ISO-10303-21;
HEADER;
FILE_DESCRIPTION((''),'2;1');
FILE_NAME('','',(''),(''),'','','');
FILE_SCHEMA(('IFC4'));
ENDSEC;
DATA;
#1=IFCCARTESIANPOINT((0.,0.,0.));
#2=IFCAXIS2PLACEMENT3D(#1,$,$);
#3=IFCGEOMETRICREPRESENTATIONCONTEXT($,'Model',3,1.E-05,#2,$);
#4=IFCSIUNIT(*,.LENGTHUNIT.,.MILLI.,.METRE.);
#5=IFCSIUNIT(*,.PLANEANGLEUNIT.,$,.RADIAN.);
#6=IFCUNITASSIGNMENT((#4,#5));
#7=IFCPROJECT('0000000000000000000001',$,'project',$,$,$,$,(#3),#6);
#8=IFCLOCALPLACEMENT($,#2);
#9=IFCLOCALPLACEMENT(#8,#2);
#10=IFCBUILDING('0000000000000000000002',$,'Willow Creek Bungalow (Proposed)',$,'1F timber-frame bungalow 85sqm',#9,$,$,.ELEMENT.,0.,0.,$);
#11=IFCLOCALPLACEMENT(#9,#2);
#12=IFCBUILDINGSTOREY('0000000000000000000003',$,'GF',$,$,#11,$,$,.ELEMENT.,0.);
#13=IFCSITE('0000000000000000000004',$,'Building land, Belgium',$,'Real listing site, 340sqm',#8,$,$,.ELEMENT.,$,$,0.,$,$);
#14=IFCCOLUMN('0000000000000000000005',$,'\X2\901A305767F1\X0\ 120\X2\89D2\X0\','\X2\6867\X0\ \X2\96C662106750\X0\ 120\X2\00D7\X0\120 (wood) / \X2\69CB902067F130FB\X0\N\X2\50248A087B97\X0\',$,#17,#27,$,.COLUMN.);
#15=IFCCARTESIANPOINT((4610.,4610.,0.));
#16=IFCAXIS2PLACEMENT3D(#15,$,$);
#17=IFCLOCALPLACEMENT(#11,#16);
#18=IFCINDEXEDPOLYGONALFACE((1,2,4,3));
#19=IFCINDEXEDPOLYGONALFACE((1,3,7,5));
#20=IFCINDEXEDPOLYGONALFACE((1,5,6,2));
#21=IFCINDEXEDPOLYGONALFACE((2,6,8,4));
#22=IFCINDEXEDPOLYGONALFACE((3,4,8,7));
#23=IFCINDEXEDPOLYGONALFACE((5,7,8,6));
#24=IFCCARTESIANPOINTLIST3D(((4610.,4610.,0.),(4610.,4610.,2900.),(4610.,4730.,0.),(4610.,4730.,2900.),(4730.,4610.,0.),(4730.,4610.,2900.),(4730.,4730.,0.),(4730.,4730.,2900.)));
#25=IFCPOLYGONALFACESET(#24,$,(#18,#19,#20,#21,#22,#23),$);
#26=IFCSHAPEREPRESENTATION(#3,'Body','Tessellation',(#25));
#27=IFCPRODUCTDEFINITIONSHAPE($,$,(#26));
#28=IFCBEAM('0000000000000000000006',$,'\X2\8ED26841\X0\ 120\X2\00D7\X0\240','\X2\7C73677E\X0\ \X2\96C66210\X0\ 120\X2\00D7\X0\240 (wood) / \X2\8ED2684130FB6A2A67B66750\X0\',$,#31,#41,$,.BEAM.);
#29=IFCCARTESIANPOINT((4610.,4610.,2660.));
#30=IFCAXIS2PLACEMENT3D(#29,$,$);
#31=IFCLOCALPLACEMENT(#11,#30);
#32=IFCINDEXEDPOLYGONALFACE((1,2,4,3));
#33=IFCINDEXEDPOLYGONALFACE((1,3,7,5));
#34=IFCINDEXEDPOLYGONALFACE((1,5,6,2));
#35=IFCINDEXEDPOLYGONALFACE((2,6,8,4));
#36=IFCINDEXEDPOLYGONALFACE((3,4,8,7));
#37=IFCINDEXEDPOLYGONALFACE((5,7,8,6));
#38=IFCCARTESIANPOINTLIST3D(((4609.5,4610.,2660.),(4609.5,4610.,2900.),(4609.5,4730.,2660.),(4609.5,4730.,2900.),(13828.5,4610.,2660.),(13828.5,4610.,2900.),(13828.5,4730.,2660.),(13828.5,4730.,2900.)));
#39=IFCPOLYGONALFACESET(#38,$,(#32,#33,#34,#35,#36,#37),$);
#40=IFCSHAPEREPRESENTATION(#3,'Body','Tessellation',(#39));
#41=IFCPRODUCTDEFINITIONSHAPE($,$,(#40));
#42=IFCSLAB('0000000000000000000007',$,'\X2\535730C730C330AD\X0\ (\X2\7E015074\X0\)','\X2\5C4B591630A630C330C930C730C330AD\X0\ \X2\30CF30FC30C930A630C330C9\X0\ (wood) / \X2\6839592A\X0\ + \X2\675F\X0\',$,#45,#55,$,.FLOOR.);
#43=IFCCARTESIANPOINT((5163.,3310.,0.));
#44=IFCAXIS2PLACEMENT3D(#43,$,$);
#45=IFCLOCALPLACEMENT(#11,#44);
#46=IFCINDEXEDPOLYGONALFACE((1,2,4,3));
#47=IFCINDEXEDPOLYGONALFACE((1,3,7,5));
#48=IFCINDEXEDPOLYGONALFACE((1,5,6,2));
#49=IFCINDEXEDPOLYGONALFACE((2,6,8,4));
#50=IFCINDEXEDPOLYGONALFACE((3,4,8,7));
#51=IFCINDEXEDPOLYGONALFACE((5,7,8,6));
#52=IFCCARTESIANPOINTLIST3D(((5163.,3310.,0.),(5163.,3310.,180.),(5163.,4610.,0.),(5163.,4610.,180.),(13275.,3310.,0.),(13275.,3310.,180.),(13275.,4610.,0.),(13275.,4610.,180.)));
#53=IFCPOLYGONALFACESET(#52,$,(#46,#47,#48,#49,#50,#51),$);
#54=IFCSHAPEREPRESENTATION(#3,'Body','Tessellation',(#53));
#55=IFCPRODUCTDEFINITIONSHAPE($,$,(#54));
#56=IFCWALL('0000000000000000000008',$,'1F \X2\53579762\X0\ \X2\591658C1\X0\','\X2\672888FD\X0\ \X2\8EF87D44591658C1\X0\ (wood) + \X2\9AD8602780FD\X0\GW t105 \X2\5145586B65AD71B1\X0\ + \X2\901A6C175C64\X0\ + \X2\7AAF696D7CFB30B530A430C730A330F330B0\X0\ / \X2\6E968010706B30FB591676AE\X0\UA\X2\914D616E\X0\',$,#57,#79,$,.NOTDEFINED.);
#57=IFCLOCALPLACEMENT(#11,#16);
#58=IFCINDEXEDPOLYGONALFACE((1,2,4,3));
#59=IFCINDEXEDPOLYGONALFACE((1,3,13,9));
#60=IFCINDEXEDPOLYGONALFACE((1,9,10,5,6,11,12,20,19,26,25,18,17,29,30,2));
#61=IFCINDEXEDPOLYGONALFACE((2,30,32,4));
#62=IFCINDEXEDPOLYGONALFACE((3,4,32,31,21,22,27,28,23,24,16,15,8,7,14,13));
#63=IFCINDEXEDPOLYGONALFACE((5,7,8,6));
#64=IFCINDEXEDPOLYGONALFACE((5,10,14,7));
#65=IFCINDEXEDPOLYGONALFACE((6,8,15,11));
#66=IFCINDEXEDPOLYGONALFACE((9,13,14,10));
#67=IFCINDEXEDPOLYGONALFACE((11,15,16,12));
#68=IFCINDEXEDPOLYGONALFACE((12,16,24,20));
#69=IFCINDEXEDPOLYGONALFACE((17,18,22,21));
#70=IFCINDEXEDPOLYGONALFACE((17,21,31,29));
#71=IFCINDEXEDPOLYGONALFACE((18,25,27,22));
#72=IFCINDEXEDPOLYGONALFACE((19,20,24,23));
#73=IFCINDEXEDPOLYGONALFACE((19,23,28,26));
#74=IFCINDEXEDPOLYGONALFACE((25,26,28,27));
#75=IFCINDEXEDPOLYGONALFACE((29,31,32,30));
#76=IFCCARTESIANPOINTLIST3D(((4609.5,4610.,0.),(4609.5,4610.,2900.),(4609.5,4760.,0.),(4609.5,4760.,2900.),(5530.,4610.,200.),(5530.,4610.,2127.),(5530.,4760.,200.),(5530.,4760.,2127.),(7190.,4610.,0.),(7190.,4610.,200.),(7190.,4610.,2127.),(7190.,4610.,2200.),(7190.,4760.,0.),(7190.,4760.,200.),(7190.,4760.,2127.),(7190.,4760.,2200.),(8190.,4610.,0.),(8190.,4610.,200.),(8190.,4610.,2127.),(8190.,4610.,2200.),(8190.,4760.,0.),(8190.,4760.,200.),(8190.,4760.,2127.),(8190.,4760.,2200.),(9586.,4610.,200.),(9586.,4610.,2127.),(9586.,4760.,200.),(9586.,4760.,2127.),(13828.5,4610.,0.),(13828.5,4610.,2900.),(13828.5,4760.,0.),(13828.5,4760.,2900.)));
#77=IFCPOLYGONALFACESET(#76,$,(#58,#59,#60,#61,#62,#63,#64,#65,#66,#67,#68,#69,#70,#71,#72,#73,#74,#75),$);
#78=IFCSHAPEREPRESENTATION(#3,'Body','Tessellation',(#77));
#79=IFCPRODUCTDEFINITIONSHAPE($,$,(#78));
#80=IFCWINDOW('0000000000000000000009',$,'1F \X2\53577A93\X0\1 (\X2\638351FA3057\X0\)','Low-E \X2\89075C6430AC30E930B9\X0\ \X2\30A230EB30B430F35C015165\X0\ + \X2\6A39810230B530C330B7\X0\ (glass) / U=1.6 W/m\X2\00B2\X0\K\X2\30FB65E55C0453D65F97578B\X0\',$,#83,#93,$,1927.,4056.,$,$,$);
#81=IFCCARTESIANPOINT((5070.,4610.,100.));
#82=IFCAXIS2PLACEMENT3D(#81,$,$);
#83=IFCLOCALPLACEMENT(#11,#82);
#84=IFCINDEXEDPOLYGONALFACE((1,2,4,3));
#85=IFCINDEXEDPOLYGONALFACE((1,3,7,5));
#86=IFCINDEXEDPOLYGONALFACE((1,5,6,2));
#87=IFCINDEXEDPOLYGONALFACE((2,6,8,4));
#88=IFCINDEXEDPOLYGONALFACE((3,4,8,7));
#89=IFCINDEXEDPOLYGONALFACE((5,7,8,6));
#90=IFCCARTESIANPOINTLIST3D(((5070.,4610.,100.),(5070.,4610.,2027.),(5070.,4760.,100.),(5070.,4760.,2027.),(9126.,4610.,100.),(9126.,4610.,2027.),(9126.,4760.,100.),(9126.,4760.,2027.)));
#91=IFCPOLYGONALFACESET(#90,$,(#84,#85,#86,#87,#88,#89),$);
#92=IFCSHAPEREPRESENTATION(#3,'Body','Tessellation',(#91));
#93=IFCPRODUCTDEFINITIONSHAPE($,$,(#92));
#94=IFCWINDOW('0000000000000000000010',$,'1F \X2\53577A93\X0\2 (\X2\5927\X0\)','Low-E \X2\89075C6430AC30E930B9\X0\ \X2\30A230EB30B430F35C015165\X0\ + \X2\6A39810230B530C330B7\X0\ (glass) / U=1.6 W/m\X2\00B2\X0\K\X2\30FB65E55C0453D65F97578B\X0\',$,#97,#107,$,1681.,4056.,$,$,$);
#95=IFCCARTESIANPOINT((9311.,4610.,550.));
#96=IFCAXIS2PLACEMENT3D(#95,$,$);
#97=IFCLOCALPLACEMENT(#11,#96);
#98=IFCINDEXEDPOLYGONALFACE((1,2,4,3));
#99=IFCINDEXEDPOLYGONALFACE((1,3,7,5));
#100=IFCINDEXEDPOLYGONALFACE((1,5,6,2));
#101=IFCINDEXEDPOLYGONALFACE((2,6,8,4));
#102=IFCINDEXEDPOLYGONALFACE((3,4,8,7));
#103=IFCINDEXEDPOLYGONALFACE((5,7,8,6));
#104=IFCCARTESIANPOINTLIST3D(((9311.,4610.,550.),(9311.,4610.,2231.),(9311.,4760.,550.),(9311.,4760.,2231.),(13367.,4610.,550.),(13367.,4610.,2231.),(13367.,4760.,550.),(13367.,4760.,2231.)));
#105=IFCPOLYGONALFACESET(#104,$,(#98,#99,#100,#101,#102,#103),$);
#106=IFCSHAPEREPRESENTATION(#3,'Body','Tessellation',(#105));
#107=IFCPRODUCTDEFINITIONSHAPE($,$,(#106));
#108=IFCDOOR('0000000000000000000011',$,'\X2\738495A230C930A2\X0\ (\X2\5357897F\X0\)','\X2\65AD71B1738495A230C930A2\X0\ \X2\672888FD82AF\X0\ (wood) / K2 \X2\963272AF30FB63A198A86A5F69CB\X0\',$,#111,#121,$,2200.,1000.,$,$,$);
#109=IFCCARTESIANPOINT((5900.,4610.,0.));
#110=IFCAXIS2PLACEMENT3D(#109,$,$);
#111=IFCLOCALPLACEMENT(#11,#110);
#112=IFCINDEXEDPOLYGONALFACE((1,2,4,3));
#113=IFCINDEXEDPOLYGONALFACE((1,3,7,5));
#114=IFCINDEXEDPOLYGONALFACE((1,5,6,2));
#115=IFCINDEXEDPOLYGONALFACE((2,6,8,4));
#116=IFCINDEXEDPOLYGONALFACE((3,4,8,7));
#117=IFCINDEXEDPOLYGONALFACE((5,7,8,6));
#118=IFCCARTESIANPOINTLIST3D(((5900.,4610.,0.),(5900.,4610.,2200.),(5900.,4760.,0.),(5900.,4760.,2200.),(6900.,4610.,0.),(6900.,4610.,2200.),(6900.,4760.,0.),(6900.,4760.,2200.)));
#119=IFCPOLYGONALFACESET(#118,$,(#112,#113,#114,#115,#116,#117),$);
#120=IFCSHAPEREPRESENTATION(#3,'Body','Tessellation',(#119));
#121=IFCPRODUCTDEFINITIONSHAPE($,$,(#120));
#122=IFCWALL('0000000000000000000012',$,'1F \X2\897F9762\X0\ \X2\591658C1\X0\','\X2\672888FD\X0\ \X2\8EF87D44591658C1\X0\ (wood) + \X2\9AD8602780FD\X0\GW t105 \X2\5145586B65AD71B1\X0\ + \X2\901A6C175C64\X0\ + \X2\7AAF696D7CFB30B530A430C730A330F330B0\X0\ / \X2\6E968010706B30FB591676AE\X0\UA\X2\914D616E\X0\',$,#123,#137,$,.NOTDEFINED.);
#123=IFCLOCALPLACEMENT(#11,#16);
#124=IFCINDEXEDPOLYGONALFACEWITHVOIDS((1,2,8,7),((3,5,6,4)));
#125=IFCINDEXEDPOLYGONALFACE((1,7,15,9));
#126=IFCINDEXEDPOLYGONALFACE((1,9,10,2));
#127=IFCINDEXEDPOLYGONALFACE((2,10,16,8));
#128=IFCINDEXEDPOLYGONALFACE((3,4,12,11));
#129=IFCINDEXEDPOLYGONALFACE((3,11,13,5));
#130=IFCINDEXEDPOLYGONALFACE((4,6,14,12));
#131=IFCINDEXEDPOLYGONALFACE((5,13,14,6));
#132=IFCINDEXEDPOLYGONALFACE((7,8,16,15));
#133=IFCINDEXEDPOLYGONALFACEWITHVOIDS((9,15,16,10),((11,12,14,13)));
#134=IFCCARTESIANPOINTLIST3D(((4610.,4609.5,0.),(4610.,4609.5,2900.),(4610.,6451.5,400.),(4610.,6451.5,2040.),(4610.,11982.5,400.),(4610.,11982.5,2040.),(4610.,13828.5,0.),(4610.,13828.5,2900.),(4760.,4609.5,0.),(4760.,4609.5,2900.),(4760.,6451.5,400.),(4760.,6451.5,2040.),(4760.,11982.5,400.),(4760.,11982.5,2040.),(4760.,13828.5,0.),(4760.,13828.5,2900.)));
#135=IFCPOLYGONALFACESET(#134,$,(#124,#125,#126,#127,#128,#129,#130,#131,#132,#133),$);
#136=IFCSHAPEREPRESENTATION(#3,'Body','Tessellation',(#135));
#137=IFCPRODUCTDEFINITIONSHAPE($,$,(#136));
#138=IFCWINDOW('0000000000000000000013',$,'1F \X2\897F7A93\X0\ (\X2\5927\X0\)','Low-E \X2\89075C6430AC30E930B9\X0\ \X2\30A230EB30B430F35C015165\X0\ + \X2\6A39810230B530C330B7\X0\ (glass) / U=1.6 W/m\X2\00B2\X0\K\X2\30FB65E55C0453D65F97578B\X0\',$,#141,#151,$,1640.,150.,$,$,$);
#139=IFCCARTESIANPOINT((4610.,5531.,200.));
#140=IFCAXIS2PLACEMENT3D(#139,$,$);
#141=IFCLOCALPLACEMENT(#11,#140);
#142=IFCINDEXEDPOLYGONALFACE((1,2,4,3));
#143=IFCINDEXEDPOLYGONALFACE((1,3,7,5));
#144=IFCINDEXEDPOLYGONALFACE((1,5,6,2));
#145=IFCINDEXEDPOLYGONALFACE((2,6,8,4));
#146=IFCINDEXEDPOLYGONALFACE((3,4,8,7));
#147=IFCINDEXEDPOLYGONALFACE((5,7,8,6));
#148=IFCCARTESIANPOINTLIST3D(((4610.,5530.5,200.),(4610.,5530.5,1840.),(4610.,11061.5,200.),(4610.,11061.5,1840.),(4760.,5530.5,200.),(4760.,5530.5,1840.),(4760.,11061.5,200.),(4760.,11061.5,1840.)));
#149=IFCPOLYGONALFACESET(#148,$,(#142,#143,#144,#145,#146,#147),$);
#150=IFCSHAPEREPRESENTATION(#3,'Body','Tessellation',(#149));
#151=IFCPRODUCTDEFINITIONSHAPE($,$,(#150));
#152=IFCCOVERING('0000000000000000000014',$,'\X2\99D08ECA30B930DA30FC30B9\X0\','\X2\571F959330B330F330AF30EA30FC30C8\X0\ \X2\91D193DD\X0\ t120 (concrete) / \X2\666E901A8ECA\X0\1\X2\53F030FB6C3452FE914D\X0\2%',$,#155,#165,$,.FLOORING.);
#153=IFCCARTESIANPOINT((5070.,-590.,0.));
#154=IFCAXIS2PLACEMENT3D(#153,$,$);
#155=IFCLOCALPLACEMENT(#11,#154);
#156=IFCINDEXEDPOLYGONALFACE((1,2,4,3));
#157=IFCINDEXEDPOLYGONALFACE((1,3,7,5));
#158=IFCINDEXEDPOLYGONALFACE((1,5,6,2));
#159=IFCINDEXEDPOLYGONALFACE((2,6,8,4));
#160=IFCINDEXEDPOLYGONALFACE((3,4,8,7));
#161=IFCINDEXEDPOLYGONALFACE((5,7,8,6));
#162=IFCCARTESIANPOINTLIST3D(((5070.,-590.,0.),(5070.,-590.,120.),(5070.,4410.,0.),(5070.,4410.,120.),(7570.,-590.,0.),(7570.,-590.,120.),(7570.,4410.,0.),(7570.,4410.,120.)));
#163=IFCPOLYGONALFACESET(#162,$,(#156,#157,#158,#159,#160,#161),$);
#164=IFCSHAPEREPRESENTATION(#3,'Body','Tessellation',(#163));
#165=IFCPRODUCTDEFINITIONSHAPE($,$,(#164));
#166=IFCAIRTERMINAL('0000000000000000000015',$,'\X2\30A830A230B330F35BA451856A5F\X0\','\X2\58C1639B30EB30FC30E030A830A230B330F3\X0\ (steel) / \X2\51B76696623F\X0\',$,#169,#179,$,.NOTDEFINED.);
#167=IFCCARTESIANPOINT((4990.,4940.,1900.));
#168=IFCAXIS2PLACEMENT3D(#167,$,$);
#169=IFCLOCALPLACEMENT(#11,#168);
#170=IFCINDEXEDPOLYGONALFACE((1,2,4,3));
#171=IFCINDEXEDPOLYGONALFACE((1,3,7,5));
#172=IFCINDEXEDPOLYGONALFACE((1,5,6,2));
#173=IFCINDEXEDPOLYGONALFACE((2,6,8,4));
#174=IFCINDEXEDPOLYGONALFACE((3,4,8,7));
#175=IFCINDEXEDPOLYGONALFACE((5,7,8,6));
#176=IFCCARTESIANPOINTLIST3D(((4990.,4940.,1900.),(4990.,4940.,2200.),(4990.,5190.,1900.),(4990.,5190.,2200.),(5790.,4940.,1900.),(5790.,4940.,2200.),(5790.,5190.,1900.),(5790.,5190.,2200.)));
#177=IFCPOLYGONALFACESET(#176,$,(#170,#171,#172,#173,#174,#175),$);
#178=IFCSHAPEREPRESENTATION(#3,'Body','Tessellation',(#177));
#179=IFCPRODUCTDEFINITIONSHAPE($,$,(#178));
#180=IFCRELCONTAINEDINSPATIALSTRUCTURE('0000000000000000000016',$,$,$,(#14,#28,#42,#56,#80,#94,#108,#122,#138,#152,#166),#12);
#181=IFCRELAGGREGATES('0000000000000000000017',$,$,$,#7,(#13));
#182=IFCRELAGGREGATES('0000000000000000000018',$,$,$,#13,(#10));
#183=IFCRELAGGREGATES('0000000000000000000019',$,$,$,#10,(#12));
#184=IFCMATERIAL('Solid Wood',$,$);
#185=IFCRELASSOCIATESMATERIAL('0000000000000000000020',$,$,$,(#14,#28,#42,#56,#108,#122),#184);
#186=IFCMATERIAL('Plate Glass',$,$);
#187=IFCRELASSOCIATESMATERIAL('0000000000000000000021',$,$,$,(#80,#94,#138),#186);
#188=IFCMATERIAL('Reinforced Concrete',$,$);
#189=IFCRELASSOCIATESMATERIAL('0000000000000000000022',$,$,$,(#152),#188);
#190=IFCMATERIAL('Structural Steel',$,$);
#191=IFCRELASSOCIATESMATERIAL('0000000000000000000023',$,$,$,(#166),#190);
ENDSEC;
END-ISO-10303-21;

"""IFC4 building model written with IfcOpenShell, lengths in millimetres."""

from ifc_helpers import new_model, si_unit, frame, frame_2d, origin, place, context, project, spatial, rectangle, extrude, material, element, fill, save


model = new_model("IFC4")

# Units and contexts
model_context = context("Model", 3, precision=1e-05, world=origin())
ifc_project = project(units=[si_unit("LENGTHUNIT", "METRE", prefix="MILLI"), si_unit("PLANEANGLEUNIT", "RADIAN")], contexts=[model_context])

# Site, building, storey
site_placement = place(None, origin())
site = spatial("IfcSite", under=ifc_project, at=site_placement, Name="Building land, Belgium", ObjectType="Real listing site, 340sqm", CompositionType="ELEMENT", RefElevation=0.0)
building_placement = place(site_placement, origin())
building = spatial("IfcBuilding", under=site, at=building_placement, Name="Willow Creek Bungalow (Proposed)", ObjectType="1F timber-frame bungalow 85sqm", CompositionType="ELEMENT", ElevationOfRefHeight=0.0, ElevationOfTerrain=0.0)
storey_placement = place(building_placement, origin())
storey = spatial("IfcBuildingStorey", under=building, at=storey_placement, Name="GF", CompositionType="ELEMENT", Elevation=0.0)

# Column
ifc_material_1 = material(Name="Solid Wood")
column_1_placement = place(storey_placement, frame((4610.0, 4610.0, 0.0)))
element("IfcColumn", 1, at=column_1_placement, inside=storey, material=ifc_material_1, Name="通し柱 120角", Description="桧 集成材 120×120 (wood) / 構造柱・N値計算", PredefinedType="COLUMN", context=model_context, shape_type="SweptSolid", body=[
    extrude(rectangle(XDim=120.0, YDim=120.0, at=frame_2d((60.0, 60.0))), frame((4610.0, 4610.0, 0.0)), (0.0, 0.0, 1.0), 2900.0),
])

# Beam
beam_1_placement = place(storey_placement, frame((4610.0, 4610.0, 2660.0)))
element("IfcBeam", 2, at=beam_1_placement, inside=storey, material=ifc_material_1, Name="軒桁 120×240", Description="米松 集成 120×240 (wood) / 軒桁・横架材", PredefinedType="BEAM", context=model_context, shape_type="SweptSolid", body=[
    extrude(rectangle(XDim=9219.0, YDim=120.0, at=frame_2d((4609.0, 60.0))), frame((4610.0, 4610.0, 2660.0)), (0.0, 0.0, 1.0), 240.0),
])

# Slab
ifc_material_2 = material(Name="Reinforced Concrete")
slab_1_placement = place(storey_placement, frame((5163.0, 3310.0, 0.0)))
element("IfcSlab", 3, at=slab_1_placement, inside=storey, material=ifc_material_1, Name="南デッキ (縁側)", Description="屋外ウッドデッキ ハードウッド (wood) / 根太 + 束", PredefinedType="FLOOR", context=model_context, shape_type="SweptSolid", body=[
    extrude(rectangle(XDim=8112.0, YDim=1300.0, at=frame_2d((4056.0, 650.0))), frame((5163.0, 3310.0, 0.0)), (0.0, 0.0, 1.0), 180.0),
])

# Wall, openings, windows, door
wall_1_placement = place(storey_placement, frame((4610.0, 4610.0, 0.0)))
wall_1 = element("IfcWall", 4, at=wall_1_placement, inside=storey, material=ifc_material_1, Name="1F 南面 外壁", Description="木製 軸組外壁 (wood) + 高性能GW t105 充填断熱 + 通気層 + 窯業系サイディング / 準耐火・外皮UA配慮", PredefinedType="NOTDEFINED", context=model_context, shape_type="SweptSolid", body=[
    extrude(rectangle(XDim=9219.0, YDim=150.0, at=frame_2d((4609.0, 75.0))), frame((4610.0, 4610.0, 0.0)), (0.0, 0.0, 1.0), 2900.0),
])
opening_1_placement = place(storey_placement, frame((5070.0, 4610.0, 100.0)))
opening_1 = element("IfcOpeningElement", 5, at=opening_1_placement, cuts=wall_1, PredefinedType="NOTDEFINED", context=model_context, shape_type="SweptSolid", body=[
    extrude(rectangle(XDim=4056.0, YDim=150.0, at=frame_2d((2028.0, 75.0))), frame((5070.0, 4610.0, 100.0)), (0.0, 0.0, 1.0), 1927.0),
])
opening_2_placement = place(storey_placement, frame((9311.0, 4610.0, 550.0)))
opening_2 = element("IfcOpeningElement", 6, at=opening_2_placement, cuts=wall_1, PredefinedType="NOTDEFINED", context=model_context, shape_type="SweptSolid", body=[
    extrude(rectangle(XDim=4056.0, YDim=150.0, at=frame_2d((2028.0, 75.0))), frame((9311.0, 4610.0, 550.0)), (0.0, 0.0, 1.0), 1681.0),
])
opening_3_placement = place(storey_placement, frame((5900.0, 4610.0, 0.0)))
opening_3 = element("IfcOpeningElement", 7, at=opening_3_placement, cuts=wall_1, PredefinedType="NOTDEFINED", context=model_context, shape_type="SweptSolid", body=[
    extrude(rectangle(XDim=1000.0, YDim=150.0, at=frame_2d((500.0, 75.0))), frame((5900.0, 4610.0, 0.0)), (0.0, 0.0, 1.0), 2200.0),
])
ifc_material_3 = material(Name="Plate Glass")
window_1_placement = place(storey_placement, frame((5070.0, 4610.0, 100.0)))
window_1 = element("IfcWindow", 8, at=window_1_placement, inside=storey, material=ifc_material_3, Name="1F 南窓1 (掃出し)", Description="Low-E 複層ガラス アルゴン封入 + 樹脂サッシ (glass) / U=1.6 W/m²K・日射取得型", OverallHeight=1927.0, OverallWidth=4056.0, context=model_context, shape_type="SweptSolid", body=[
    extrude(rectangle(XDim=4056.0, YDim=150.0, at=frame_2d((2028.0, 75.0))), frame((5070.0, 4610.0, 100.0)), (0.0, 0.0, 1.0), 1927.0),
])
fill(opening_1, window_1)
window_2_placement = place(storey_placement, frame((9311.0, 4610.0, 550.0)))
window_2 = element("IfcWindow", 9, at=window_2_placement, inside=storey, material=ifc_material_3, Name="1F 南窓2 (大)", Description="Low-E 複層ガラス アルゴン封入 + 樹脂サッシ (glass) / U=1.6 W/m²K・日射取得型", OverallHeight=1681.0, OverallWidth=4056.0, context=model_context, shape_type="SweptSolid", body=[
    extrude(rectangle(XDim=4056.0, YDim=150.0, at=frame_2d((2028.0, 75.0))), frame((9311.0, 4610.0, 550.0)), (0.0, 0.0, 1.0), 1681.0),
])
fill(opening_2, window_2)
door_placement = place(storey_placement, frame((5900.0, 4610.0, 0.0)))
door = element("IfcDoor", 10, at=door_placement, inside=storey, material=ifc_material_1, Name="玄関ドア (南西)", Description="断熱玄関ドア 木製芯 (wood) / K2 防犯・採風機構", OverallHeight=2200.0, OverallWidth=1000.0, context=model_context, shape_type="SweptSolid", body=[
    extrude(rectangle(XDim=1000.0, YDim=150.0, at=frame_2d((500.0, 75.0))), frame((5900.0, 4610.0, 0.0)), (0.0, 0.0, 1.0), 2200.0),
])
fill(opening_3, door)

# Wall, opening, window
wall_2_placement = place(storey_placement, frame((4610.0, 4610.0, 0.0)))
wall_2 = element("IfcWall", 11, at=wall_2_placement, inside=storey, material=ifc_material_1, Name="1F 西面 外壁", Description="木製 軸組外壁 (wood) + 高性能GW t105 充填断熱 + 通気層 + 窯業系サイディング / 準耐火・外皮UA配慮", PredefinedType="NOTDEFINED", context=model_context, shape_type="SweptSolid", body=[
    extrude(rectangle(XDim=150.0, YDim=9219.0, at=frame_2d((75.0, 4609.0))), frame((4610.0, 4610.0, 0.0)), (0.0, 0.0, 1.0), 2900.0),
])
opening_4_placement = place(storey_placement, frame((4610.0, 5531.0, 200.0)))
opening_4 = element("IfcOpeningElement", 12, at=opening_4_placement, cuts=wall_2, PredefinedType="NOTDEFINED", context=model_context, shape_type="SweptSolid", body=[
    extrude(rectangle(XDim=150.0, YDim=5531.0, at=frame_2d((75.0, 2765.0))), frame((4610.0, 5531.0, 200.0)), (0.0, 0.0, 1.0), 1640.0),
])
window_3_placement = place(storey_placement, frame((4610.0, 5531.0, 200.0)))
window_3 = element("IfcWindow", 13, at=window_3_placement, inside=storey, material=ifc_material_3, Name="1F 西窓 (大)", Description="Low-E 複層ガラス アルゴン封入 + 樹脂サッシ (glass) / U=1.6 W/m²K・日射取得型", OverallHeight=1640.0, OverallWidth=150.0, context=model_context, shape_type="SweptSolid", body=[
    extrude(rectangle(XDim=150.0, YDim=5531.0, at=frame_2d((75.0, 2765.0))), frame((4610.0, 5531.0, 200.0)), (0.0, 0.0, 1.0), 1640.0),
])
fill(opening_4, window_3)

# Shared definitions
ifc_material_4 = material(Name="Structural Steel")

# Covering
covering_1_placement = place(storey_placement, frame((5070.0, -590.0, 0.0)))
element("IfcCovering", 14, at=covering_1_placement, inside=storey, material=ifc_material_2, Name="駐車スペース", Description="土間コンクリート 金鏝 t120 (concrete) / 普通車1台・水勾配2%", PredefinedType="FLOORING", context=model_context, shape_type="SweptSolid", body=[
    extrude(rectangle(XDim=2500.0, YDim=5000.0, at=frame_2d((1250.0, 2500.0))), frame((5070.0, -590.0, 0.0)), (0.0, 0.0, 1.0), 120.0),
])

# Air terminal
air_terminal_placement = place(storey_placement, frame((4990.0, 4940.0, 1900.0)))
element("IfcAirTerminal", 15, at=air_terminal_placement, inside=storey, material=ifc_material_4, Name="エアコン室内機", Description="壁掛ルームエアコン (steel) / 冷暖房", PredefinedType="NOTDEFINED", context=model_context, shape_type="SweptSolid", body=[
    extrude(rectangle(XDim=800.0, YDim=250.0, at=frame_2d((400.0, 125.0))), frame((4990.0, 4940.0, 1900.0)), (0.0, 0.0, 1.0), 300.0),
])

save(model, "model.ifc")
